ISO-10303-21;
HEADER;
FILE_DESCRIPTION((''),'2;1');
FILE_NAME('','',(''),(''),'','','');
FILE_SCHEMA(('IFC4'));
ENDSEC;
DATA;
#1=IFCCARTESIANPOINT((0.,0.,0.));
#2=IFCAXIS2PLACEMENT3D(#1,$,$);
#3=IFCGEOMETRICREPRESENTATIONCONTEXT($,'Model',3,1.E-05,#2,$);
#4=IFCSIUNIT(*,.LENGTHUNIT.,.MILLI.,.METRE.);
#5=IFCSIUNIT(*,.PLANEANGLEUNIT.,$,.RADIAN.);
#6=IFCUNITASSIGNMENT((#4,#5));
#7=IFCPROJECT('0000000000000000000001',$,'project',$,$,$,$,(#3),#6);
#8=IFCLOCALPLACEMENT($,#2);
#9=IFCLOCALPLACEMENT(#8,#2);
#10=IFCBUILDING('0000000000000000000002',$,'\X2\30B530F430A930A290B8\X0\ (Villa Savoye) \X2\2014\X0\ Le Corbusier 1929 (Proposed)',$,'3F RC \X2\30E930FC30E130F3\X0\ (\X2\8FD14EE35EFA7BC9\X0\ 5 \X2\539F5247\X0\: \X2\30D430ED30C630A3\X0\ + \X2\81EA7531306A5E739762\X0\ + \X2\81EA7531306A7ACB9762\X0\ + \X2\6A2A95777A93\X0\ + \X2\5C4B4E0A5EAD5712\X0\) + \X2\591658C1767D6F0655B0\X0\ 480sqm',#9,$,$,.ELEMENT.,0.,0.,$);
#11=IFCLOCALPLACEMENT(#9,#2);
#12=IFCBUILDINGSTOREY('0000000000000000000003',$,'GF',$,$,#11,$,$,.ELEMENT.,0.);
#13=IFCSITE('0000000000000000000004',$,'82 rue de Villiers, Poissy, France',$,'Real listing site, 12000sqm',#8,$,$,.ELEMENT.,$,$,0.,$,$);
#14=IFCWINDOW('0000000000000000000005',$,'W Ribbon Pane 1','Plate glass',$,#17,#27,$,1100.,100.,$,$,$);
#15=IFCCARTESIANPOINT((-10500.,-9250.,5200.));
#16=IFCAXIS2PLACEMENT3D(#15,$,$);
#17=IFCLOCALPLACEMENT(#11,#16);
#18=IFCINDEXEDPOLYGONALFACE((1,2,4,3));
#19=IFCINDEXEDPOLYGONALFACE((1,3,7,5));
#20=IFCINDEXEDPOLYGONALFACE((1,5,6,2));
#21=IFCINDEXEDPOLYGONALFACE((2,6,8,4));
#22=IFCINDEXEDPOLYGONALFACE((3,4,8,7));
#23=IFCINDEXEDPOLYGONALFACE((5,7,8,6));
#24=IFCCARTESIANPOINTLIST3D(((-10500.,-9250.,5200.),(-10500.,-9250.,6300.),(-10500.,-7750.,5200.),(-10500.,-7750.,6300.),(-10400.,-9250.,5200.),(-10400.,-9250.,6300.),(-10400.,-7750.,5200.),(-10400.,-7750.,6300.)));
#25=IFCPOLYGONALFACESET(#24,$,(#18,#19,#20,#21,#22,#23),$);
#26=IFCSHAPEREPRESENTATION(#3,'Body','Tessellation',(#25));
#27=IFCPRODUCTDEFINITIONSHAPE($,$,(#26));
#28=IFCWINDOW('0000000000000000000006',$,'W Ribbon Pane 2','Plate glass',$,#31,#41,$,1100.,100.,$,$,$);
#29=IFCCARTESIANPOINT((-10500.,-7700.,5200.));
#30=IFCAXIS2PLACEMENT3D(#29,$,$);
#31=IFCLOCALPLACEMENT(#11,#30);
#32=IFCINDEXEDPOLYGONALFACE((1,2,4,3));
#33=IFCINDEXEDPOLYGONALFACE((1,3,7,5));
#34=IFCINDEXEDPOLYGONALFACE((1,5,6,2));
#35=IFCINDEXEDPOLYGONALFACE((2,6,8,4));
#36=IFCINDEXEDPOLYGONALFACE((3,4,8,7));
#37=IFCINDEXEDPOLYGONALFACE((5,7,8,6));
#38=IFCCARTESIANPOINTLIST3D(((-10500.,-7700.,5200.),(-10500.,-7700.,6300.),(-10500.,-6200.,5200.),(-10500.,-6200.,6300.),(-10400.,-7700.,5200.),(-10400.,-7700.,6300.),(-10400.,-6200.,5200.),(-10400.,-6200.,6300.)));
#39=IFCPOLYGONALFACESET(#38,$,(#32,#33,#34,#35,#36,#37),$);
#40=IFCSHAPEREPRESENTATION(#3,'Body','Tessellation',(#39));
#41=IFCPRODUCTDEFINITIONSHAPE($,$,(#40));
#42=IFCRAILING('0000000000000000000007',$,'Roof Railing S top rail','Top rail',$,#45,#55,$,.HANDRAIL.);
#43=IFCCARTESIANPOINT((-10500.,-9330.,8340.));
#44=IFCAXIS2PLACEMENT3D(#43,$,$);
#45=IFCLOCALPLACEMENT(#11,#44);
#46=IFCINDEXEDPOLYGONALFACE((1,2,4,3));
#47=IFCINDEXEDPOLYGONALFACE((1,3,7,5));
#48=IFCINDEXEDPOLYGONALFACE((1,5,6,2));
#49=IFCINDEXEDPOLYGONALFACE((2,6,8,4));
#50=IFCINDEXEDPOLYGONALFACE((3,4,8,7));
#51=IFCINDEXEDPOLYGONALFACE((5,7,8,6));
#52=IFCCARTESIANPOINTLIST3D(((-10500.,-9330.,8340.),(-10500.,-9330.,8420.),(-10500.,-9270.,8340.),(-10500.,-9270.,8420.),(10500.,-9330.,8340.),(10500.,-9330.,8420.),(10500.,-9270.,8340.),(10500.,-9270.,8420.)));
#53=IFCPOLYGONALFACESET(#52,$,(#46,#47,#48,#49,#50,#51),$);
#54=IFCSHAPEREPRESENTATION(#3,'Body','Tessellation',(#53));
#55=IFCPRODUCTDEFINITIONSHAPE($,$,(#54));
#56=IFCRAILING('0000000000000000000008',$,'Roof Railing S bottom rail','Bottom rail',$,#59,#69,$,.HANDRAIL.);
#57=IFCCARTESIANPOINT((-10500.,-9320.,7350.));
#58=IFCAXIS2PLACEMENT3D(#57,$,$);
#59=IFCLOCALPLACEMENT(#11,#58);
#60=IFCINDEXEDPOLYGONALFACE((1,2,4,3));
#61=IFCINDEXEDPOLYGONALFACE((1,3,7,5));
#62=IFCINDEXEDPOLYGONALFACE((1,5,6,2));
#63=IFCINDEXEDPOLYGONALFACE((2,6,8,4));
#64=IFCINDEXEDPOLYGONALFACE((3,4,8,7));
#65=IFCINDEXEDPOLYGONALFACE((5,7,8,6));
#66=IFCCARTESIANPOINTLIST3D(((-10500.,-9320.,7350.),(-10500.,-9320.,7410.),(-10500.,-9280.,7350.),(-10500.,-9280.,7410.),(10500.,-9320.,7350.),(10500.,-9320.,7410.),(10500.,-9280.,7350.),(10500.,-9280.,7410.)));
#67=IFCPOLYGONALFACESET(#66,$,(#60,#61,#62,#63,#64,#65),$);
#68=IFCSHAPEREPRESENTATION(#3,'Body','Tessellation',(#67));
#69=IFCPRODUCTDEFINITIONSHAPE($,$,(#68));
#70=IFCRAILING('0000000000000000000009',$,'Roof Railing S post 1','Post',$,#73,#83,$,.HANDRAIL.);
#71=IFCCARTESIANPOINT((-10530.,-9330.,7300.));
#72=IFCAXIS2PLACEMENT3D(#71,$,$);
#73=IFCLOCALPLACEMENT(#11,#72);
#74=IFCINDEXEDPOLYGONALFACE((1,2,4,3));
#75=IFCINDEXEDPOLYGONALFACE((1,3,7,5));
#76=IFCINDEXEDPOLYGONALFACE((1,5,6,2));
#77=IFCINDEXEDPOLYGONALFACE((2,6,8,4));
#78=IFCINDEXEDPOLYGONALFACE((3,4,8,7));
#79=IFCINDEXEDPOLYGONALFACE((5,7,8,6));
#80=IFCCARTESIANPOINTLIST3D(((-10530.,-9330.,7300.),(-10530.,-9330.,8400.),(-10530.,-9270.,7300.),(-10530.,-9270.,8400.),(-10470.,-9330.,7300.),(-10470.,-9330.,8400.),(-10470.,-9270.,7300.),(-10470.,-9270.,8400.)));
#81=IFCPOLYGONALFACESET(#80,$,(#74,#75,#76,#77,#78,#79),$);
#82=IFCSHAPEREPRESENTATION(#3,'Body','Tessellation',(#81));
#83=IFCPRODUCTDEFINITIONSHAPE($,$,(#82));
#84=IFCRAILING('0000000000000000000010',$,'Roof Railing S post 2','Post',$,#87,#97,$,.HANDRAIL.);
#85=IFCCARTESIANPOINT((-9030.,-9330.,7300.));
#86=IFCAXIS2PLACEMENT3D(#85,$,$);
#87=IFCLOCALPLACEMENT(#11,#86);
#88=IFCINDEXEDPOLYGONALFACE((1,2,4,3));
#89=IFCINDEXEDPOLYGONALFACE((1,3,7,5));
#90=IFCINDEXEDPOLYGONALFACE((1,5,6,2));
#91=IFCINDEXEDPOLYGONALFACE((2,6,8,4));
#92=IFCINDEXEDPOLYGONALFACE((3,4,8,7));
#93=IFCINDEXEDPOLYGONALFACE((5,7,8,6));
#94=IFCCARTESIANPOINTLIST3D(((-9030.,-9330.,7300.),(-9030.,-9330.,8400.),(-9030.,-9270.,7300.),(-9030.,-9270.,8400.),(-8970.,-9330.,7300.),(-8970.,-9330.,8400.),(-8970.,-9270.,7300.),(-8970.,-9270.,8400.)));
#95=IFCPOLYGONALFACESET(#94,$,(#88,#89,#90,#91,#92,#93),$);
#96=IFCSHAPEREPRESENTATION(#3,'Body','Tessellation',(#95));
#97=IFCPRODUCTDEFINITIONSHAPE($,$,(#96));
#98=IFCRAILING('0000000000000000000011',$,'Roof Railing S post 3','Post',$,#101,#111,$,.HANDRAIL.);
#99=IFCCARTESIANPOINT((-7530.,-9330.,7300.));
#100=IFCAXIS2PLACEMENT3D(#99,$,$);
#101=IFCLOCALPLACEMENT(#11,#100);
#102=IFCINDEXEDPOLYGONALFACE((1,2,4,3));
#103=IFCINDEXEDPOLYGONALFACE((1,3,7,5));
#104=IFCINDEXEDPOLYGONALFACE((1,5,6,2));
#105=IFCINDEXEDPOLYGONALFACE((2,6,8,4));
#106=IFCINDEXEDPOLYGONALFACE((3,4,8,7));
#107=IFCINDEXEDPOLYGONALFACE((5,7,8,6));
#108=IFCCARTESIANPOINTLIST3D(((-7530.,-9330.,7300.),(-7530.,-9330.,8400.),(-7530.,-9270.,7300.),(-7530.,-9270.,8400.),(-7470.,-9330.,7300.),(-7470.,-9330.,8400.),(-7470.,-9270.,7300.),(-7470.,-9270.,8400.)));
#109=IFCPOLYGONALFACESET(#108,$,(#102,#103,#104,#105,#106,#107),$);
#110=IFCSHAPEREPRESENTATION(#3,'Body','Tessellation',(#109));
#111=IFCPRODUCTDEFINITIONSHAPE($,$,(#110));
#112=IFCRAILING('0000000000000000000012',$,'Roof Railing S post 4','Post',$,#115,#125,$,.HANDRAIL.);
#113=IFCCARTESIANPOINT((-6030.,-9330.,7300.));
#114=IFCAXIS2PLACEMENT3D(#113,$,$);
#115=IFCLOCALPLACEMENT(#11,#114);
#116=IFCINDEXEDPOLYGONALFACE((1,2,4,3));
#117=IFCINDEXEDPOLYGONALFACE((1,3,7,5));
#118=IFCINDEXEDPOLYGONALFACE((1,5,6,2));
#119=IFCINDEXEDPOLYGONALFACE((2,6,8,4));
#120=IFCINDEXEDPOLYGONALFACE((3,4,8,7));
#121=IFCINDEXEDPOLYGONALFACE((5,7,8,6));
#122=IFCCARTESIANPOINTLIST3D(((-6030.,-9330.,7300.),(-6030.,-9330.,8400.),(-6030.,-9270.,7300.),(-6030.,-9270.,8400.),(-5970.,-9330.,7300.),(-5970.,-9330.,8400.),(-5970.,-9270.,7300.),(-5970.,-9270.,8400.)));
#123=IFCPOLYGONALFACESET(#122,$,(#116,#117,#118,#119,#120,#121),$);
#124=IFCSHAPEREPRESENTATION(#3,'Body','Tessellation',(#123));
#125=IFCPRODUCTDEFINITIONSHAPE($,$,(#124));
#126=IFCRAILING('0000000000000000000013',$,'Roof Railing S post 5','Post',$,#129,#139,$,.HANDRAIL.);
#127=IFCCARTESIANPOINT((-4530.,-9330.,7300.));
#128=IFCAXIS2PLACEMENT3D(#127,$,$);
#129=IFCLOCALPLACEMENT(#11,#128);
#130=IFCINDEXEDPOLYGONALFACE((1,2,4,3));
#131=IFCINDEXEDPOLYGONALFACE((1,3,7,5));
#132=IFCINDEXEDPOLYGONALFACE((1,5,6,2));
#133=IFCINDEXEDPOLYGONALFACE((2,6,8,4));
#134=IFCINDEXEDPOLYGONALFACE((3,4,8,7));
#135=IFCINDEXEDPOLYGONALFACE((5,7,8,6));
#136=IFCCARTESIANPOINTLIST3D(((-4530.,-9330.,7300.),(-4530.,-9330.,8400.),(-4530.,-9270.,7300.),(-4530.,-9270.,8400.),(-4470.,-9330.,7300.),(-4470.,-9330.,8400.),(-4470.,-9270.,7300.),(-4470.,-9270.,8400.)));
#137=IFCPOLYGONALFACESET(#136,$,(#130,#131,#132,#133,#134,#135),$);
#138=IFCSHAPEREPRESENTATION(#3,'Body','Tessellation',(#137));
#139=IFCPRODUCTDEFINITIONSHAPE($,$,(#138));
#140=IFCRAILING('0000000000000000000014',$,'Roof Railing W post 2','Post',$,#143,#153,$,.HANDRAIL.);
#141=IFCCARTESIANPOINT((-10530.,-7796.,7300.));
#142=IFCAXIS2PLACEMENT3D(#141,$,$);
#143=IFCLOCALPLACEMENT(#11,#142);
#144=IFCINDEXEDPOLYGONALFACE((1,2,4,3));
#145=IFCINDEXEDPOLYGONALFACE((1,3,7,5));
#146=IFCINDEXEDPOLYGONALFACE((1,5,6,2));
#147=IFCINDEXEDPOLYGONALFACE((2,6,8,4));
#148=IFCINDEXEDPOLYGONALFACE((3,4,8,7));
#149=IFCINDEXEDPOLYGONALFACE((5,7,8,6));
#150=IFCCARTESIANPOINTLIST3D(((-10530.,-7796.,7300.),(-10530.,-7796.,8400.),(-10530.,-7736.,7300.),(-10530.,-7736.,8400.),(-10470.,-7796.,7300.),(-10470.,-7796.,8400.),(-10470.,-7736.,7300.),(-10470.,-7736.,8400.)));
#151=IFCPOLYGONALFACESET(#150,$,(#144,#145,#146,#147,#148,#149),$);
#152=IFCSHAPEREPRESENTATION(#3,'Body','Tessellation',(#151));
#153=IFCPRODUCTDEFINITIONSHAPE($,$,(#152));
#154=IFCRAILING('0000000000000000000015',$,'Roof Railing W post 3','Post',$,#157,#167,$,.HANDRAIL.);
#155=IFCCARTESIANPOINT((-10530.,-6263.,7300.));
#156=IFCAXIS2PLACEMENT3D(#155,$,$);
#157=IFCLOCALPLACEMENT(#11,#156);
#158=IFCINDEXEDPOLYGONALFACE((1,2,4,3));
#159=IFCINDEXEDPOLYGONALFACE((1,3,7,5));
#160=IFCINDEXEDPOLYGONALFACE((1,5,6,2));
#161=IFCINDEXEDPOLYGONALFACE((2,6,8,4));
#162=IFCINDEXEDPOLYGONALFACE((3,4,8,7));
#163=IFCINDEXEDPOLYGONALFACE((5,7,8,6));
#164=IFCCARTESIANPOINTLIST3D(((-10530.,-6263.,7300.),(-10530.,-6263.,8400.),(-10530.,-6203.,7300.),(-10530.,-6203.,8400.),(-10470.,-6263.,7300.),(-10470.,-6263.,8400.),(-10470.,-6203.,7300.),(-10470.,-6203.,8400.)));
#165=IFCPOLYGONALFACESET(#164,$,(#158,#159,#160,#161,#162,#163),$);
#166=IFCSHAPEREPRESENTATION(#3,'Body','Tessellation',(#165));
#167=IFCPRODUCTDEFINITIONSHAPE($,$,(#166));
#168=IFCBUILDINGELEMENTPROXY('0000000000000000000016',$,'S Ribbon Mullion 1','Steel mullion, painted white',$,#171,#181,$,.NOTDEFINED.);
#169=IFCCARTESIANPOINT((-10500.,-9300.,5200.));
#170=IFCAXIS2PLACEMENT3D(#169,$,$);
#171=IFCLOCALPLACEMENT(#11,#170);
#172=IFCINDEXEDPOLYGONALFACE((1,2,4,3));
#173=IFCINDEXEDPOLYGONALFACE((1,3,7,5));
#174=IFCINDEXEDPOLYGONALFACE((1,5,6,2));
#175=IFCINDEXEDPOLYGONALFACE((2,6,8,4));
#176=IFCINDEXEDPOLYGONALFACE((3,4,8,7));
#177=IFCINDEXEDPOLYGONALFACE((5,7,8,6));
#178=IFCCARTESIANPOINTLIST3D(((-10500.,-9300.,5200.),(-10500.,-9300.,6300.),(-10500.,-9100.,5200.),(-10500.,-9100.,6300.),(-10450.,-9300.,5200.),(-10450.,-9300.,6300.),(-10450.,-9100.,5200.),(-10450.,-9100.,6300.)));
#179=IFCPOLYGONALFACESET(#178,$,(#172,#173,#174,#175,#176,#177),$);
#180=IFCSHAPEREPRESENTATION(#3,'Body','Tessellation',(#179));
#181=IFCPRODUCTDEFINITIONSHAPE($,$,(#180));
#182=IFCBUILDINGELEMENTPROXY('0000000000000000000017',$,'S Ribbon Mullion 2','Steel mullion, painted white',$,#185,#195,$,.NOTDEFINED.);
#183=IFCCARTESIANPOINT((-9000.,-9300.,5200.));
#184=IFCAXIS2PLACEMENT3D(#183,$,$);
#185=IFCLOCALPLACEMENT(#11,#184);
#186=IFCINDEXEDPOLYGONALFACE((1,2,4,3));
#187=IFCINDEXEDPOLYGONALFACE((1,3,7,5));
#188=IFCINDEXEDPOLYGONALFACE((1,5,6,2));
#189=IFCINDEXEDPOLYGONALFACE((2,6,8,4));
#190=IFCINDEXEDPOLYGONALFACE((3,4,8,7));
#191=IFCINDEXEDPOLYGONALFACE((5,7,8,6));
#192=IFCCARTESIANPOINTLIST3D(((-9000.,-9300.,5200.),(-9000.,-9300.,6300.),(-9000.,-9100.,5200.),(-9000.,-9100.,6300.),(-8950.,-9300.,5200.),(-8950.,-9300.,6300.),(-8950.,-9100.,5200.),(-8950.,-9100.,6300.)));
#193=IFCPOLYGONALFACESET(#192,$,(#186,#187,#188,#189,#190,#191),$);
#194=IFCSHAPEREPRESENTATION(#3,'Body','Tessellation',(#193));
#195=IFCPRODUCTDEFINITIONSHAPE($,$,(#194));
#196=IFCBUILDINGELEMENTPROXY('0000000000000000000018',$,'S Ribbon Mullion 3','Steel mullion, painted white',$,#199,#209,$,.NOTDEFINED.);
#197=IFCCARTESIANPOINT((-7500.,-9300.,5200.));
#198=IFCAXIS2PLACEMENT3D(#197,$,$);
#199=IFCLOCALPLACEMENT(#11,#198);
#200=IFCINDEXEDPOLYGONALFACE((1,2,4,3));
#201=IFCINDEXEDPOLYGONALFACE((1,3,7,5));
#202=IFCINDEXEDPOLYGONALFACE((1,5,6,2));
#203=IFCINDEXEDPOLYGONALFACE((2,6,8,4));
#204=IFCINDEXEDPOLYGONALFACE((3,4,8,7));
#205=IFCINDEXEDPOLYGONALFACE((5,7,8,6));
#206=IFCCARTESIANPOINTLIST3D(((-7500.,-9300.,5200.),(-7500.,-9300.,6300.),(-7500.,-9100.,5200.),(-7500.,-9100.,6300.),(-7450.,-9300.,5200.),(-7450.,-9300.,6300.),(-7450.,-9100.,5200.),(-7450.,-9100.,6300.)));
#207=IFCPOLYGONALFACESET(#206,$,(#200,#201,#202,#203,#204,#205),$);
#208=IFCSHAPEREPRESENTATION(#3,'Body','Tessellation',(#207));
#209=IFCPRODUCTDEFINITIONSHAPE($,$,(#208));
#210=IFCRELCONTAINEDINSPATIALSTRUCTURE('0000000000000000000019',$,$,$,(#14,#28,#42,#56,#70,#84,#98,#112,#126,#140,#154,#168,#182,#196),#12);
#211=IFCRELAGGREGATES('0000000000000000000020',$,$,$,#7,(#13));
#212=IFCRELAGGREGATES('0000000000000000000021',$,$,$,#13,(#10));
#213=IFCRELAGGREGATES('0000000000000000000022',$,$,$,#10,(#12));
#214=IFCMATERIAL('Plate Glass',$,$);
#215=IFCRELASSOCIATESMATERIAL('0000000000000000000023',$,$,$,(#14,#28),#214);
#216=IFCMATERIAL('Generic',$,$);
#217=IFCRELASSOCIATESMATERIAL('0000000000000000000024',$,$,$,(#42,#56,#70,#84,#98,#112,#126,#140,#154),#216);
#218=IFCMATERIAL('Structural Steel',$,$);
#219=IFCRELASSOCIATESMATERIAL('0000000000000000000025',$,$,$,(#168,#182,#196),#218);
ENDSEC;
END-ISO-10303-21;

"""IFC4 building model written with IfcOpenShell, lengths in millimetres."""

from ifc_helpers import new_model, si_unit, frame, frame_2d, origin, place, context, project, spatial, rectangle, extrude, material, element, save


model = new_model("IFC4")

# Units and contexts
model_context = context("Model", 3, precision=1e-05, world=origin())
ifc_project = project(units=[si_unit("LENGTHUNIT", "METRE", prefix="MILLI"), si_unit("PLANEANGLEUNIT", "RADIAN")], contexts=[model_context])

# Site, building, storey
site_placement = place(None, origin())
site = spatial("IfcSite", under=ifc_project, at=site_placement, Name="82 rue de Villiers, Poissy, France", ObjectType="Real listing site, 12000sqm", CompositionType="ELEMENT", RefElevation=0.0)
building_placement = place(site_placement, origin())
building = spatial("IfcBuilding", under=site, at=building_placement, Name="サヴォア邸 (Villa Savoye) — Le Corbusier 1929 (Proposed)", ObjectType="3F RC ラーメン (近代建築 5 原則: ピロティ + 自由な平面 + 自由な立面 + 横長窓 + 屋上庭園) + 外壁白漆喰 480sqm", CompositionType="ELEMENT", ElevationOfRefHeight=0.0, ElevationOfTerrain=0.0)
storey_placement = place(building_placement, origin())
storey = spatial("IfcBuildingStorey", under=building, at=storey_placement, Name="GF", CompositionType="ELEMENT", Elevation=0.0)

# Shared definitions
ifc_material_1 = material(Name="Generic")

# Windows
ifc_material_2 = material(Name="Plate Glass")
window_1_placement = place(storey_placement, frame((-10500.0, -9250.0, 5200.0)))
element("IfcWindow", 1, at=window_1_placement, inside=storey, material=ifc_material_2, Name="W Ribbon Pane 1", Description="Plate glass", OverallHeight=1100.0, OverallWidth=100.0, context=model_context, shape_type="SweptSolid", body=[
    extrude(rectangle(XDim=100.0, YDim=1500.0, at=frame_2d((50.0, 750.0))), frame((-10500.0, -9250.0, 5200.0)), (0.0, 0.0, 1.0), 1100.0),
])
window_2_placement = place(storey_placement, frame((-10500.0, -7700.0, 5200.0)))
element("IfcWindow", 2, at=window_2_placement, inside=storey, material=ifc_material_2, Name="W Ribbon Pane 2", Description="Plate glass", OverallHeight=1100.0, OverallWidth=100.0, context=model_context, shape_type="SweptSolid", body=[
    extrude(rectangle(XDim=100.0, YDim=1500.0, at=frame_2d((50.0, 750.0))), frame((-10500.0, -7700.0, 5200.0)), (0.0, 0.0, 1.0), 1100.0),
])

# Railings
railing_1_placement = place(storey_placement, frame((-10500.0, -9330.0, 8340.0)))
element("IfcRailing", 3, at=railing_1_placement, inside=storey, material=ifc_material_1, Name="Roof Railing S top rail", Description="Top rail", PredefinedType="HANDRAIL", context=model_context, shape_type="SweptSolid", body=[
    extrude(rectangle(XDim=21000.0, YDim=60.0, at=frame_2d((10500.0, 30.0))), frame((-10500.0, -9330.0, 8340.0)), (0.0, 0.0, 1.0), 80.0),
])
railing_2_placement = place(storey_placement, frame((-10500.0, -9320.0, 7350.0)))
element("IfcRailing", 4, at=railing_2_placement, inside=storey, material=ifc_material_1, Name="Roof Railing S bottom rail", Description="Bottom rail", PredefinedType="HANDRAIL", context=model_context, shape_type="SweptSolid", body=[
    extrude(rectangle(XDim=21000.0, YDim=40.0, at=frame_2d((10500.0, 20.0))), frame((-10500.0, -9320.0, 7350.0)), (0.0, 0.0, 1.0), 60.0),
])
railing_3_placement = place(storey_placement, frame((-10530.0, -9330.0, 7300.0)))
element("IfcRailing", 5, at=railing_3_placement, inside=storey, material=ifc_material_1, Name="Roof Railing S post 1", Description="Post", PredefinedType="HANDRAIL", context=model_context, shape_type="SweptSolid", body=[
    extrude(rectangle(XDim=60.0, YDim=60.0, at=frame_2d((30.0, 30.0))), frame((-10530.0, -9330.0, 7300.0)), (0.0, 0.0, 1.0), 1100.0),
])
railing_4_placement = place(storey_placement, frame((-9030.0, -9330.0, 7300.0)))
element("IfcRailing", 6, at=railing_4_placement, inside=storey, material=ifc_material_1, Name="Roof Railing S post 2", Description="Post", PredefinedType="HANDRAIL", context=model_context, shape_type="SweptSolid", body=[
    extrude(rectangle(XDim=60.0, YDim=60.0, at=frame_2d((30.0, 30.0))), frame((-9030.0, -9330.0, 7300.0)), (0.0, 0.0, 1.0), 1100.0),
])
railing_5_placement = place(storey_placement, frame((-7530.0, -9330.0, 7300.0)))
element("IfcRailing", 7, at=railing_5_placement, inside=storey, material=ifc_material_1, Name="Roof Railing S post 3", Description="Post", PredefinedType="HANDRAIL", context=model_context, shape_type="SweptSolid", body=[
    extrude(rectangle(XDim=60.0, YDim=60.0, at=frame_2d((30.0, 30.0))), frame((-7530.0, -9330.0, 7300.0)), (0.0, 0.0, 1.0), 1100.0),
])
railing_6_placement = place(storey_placement, frame((-6030.0, -9330.0, 7300.0)))
element("IfcRailing", 8, at=railing_6_placement, inside=storey, material=ifc_material_1, Name="Roof Railing S post 4", Description="Post", PredefinedType="HANDRAIL", context=model_context, shape_type="SweptSolid", body=[
    extrude(rectangle(XDim=60.0, YDim=60.0, at=frame_2d((30.0, 30.0))), frame((-6030.0, -9330.0, 7300.0)), (0.0, 0.0, 1.0), 1100.0),
])
railing_7_placement = place(storey_placement, frame((-4530.0, -9330.0, 7300.0)))
element("IfcRailing", 9, at=railing_7_placement, inside=storey, material=ifc_material_1, Name="Roof Railing S post 5", Description="Post", PredefinedType="HANDRAIL", context=model_context, shape_type="SweptSolid", body=[
    extrude(rectangle(XDim=60.0, YDim=60.0, at=frame_2d((30.0, 30.0))), frame((-4530.0, -9330.0, 7300.0)), (0.0, 0.0, 1.0), 1100.0),
])
railing_8_placement = place(storey_placement, frame((-10530.0, -7796.0, 7300.0)))
element("IfcRailing", 10, at=railing_8_placement, inside=storey, material=ifc_material_1, Name="Roof Railing W post 2", Description="Post", PredefinedType="HANDRAIL", context=model_context, shape_type="SweptSolid", body=[
    extrude(rectangle(XDim=60.0, YDim=60.0, at=frame_2d((30.0, 30.0))), frame((-10530.0, -7796.0, 7300.0)), (0.0, 0.0, 1.0), 1100.0),
])
railing_9_placement = place(storey_placement, frame((-10530.0, -6263.0, 7300.0)))
element("IfcRailing", 11, at=railing_9_placement, inside=storey, material=ifc_material_1, Name="Roof Railing W post 3", Description="Post", PredefinedType="HANDRAIL", context=model_context, shape_type="SweptSolid", body=[
    extrude(rectangle(XDim=60.0, YDim=60.0, at=frame_2d((30.0, 30.0))), frame((-10530.0, -6263.0, 7300.0)), (0.0, 0.0, 1.0), 1100.0),
])

# Building element proxies
ifc_material_3 = material(Name="Structural Steel")
proxy_1_placement = place(storey_placement, frame((-10500.0, -9300.0, 5200.0)))
element("IfcBuildingElementProxy", 12, at=proxy_1_placement, inside=storey, material=ifc_material_3, Name="S Ribbon Mullion 1", Description="Steel mullion, painted white", PredefinedType="NOTDEFINED", context=model_context, shape_type="SweptSolid", body=[
    extrude(rectangle(XDim=50.0, YDim=200.0, at=frame_2d((25.0, 100.0))), frame((-10500.0, -9300.0, 5200.0)), (0.0, 0.0, 1.0), 1100.0),
])
proxy_2_placement = place(storey_placement, frame((-9000.0, -9300.0, 5200.0)))
element("IfcBuildingElementProxy", 13, at=proxy_2_placement, inside=storey, material=ifc_material_3, Name="S Ribbon Mullion 2", Description="Steel mullion, painted white", PredefinedType="NOTDEFINED", context=model_context, shape_type="SweptSolid", body=[
    extrude(rectangle(XDim=50.0, YDim=200.0, at=frame_2d((25.0, 100.0))), frame((-9000.0, -9300.0, 5200.0)), (0.0, 0.0, 1.0), 1100.0),
])
proxy_3_placement = place(storey_placement, frame((-7500.0, -9300.0, 5200.0)))
element("IfcBuildingElementProxy", 14, at=proxy_3_placement, inside=storey, material=ifc_material_3, Name="S Ribbon Mullion 3", Description="Steel mullion, painted white", PredefinedType="NOTDEFINED", context=model_context, shape_type="SweptSolid", body=[
    extrude(rectangle(XDim=50.0, YDim=200.0, at=frame_2d((25.0, 100.0))), frame((-7500.0, -9300.0, 5200.0)), (0.0, 0.0, 1.0), 1100.0),
])

save(model, "model.ifc")
